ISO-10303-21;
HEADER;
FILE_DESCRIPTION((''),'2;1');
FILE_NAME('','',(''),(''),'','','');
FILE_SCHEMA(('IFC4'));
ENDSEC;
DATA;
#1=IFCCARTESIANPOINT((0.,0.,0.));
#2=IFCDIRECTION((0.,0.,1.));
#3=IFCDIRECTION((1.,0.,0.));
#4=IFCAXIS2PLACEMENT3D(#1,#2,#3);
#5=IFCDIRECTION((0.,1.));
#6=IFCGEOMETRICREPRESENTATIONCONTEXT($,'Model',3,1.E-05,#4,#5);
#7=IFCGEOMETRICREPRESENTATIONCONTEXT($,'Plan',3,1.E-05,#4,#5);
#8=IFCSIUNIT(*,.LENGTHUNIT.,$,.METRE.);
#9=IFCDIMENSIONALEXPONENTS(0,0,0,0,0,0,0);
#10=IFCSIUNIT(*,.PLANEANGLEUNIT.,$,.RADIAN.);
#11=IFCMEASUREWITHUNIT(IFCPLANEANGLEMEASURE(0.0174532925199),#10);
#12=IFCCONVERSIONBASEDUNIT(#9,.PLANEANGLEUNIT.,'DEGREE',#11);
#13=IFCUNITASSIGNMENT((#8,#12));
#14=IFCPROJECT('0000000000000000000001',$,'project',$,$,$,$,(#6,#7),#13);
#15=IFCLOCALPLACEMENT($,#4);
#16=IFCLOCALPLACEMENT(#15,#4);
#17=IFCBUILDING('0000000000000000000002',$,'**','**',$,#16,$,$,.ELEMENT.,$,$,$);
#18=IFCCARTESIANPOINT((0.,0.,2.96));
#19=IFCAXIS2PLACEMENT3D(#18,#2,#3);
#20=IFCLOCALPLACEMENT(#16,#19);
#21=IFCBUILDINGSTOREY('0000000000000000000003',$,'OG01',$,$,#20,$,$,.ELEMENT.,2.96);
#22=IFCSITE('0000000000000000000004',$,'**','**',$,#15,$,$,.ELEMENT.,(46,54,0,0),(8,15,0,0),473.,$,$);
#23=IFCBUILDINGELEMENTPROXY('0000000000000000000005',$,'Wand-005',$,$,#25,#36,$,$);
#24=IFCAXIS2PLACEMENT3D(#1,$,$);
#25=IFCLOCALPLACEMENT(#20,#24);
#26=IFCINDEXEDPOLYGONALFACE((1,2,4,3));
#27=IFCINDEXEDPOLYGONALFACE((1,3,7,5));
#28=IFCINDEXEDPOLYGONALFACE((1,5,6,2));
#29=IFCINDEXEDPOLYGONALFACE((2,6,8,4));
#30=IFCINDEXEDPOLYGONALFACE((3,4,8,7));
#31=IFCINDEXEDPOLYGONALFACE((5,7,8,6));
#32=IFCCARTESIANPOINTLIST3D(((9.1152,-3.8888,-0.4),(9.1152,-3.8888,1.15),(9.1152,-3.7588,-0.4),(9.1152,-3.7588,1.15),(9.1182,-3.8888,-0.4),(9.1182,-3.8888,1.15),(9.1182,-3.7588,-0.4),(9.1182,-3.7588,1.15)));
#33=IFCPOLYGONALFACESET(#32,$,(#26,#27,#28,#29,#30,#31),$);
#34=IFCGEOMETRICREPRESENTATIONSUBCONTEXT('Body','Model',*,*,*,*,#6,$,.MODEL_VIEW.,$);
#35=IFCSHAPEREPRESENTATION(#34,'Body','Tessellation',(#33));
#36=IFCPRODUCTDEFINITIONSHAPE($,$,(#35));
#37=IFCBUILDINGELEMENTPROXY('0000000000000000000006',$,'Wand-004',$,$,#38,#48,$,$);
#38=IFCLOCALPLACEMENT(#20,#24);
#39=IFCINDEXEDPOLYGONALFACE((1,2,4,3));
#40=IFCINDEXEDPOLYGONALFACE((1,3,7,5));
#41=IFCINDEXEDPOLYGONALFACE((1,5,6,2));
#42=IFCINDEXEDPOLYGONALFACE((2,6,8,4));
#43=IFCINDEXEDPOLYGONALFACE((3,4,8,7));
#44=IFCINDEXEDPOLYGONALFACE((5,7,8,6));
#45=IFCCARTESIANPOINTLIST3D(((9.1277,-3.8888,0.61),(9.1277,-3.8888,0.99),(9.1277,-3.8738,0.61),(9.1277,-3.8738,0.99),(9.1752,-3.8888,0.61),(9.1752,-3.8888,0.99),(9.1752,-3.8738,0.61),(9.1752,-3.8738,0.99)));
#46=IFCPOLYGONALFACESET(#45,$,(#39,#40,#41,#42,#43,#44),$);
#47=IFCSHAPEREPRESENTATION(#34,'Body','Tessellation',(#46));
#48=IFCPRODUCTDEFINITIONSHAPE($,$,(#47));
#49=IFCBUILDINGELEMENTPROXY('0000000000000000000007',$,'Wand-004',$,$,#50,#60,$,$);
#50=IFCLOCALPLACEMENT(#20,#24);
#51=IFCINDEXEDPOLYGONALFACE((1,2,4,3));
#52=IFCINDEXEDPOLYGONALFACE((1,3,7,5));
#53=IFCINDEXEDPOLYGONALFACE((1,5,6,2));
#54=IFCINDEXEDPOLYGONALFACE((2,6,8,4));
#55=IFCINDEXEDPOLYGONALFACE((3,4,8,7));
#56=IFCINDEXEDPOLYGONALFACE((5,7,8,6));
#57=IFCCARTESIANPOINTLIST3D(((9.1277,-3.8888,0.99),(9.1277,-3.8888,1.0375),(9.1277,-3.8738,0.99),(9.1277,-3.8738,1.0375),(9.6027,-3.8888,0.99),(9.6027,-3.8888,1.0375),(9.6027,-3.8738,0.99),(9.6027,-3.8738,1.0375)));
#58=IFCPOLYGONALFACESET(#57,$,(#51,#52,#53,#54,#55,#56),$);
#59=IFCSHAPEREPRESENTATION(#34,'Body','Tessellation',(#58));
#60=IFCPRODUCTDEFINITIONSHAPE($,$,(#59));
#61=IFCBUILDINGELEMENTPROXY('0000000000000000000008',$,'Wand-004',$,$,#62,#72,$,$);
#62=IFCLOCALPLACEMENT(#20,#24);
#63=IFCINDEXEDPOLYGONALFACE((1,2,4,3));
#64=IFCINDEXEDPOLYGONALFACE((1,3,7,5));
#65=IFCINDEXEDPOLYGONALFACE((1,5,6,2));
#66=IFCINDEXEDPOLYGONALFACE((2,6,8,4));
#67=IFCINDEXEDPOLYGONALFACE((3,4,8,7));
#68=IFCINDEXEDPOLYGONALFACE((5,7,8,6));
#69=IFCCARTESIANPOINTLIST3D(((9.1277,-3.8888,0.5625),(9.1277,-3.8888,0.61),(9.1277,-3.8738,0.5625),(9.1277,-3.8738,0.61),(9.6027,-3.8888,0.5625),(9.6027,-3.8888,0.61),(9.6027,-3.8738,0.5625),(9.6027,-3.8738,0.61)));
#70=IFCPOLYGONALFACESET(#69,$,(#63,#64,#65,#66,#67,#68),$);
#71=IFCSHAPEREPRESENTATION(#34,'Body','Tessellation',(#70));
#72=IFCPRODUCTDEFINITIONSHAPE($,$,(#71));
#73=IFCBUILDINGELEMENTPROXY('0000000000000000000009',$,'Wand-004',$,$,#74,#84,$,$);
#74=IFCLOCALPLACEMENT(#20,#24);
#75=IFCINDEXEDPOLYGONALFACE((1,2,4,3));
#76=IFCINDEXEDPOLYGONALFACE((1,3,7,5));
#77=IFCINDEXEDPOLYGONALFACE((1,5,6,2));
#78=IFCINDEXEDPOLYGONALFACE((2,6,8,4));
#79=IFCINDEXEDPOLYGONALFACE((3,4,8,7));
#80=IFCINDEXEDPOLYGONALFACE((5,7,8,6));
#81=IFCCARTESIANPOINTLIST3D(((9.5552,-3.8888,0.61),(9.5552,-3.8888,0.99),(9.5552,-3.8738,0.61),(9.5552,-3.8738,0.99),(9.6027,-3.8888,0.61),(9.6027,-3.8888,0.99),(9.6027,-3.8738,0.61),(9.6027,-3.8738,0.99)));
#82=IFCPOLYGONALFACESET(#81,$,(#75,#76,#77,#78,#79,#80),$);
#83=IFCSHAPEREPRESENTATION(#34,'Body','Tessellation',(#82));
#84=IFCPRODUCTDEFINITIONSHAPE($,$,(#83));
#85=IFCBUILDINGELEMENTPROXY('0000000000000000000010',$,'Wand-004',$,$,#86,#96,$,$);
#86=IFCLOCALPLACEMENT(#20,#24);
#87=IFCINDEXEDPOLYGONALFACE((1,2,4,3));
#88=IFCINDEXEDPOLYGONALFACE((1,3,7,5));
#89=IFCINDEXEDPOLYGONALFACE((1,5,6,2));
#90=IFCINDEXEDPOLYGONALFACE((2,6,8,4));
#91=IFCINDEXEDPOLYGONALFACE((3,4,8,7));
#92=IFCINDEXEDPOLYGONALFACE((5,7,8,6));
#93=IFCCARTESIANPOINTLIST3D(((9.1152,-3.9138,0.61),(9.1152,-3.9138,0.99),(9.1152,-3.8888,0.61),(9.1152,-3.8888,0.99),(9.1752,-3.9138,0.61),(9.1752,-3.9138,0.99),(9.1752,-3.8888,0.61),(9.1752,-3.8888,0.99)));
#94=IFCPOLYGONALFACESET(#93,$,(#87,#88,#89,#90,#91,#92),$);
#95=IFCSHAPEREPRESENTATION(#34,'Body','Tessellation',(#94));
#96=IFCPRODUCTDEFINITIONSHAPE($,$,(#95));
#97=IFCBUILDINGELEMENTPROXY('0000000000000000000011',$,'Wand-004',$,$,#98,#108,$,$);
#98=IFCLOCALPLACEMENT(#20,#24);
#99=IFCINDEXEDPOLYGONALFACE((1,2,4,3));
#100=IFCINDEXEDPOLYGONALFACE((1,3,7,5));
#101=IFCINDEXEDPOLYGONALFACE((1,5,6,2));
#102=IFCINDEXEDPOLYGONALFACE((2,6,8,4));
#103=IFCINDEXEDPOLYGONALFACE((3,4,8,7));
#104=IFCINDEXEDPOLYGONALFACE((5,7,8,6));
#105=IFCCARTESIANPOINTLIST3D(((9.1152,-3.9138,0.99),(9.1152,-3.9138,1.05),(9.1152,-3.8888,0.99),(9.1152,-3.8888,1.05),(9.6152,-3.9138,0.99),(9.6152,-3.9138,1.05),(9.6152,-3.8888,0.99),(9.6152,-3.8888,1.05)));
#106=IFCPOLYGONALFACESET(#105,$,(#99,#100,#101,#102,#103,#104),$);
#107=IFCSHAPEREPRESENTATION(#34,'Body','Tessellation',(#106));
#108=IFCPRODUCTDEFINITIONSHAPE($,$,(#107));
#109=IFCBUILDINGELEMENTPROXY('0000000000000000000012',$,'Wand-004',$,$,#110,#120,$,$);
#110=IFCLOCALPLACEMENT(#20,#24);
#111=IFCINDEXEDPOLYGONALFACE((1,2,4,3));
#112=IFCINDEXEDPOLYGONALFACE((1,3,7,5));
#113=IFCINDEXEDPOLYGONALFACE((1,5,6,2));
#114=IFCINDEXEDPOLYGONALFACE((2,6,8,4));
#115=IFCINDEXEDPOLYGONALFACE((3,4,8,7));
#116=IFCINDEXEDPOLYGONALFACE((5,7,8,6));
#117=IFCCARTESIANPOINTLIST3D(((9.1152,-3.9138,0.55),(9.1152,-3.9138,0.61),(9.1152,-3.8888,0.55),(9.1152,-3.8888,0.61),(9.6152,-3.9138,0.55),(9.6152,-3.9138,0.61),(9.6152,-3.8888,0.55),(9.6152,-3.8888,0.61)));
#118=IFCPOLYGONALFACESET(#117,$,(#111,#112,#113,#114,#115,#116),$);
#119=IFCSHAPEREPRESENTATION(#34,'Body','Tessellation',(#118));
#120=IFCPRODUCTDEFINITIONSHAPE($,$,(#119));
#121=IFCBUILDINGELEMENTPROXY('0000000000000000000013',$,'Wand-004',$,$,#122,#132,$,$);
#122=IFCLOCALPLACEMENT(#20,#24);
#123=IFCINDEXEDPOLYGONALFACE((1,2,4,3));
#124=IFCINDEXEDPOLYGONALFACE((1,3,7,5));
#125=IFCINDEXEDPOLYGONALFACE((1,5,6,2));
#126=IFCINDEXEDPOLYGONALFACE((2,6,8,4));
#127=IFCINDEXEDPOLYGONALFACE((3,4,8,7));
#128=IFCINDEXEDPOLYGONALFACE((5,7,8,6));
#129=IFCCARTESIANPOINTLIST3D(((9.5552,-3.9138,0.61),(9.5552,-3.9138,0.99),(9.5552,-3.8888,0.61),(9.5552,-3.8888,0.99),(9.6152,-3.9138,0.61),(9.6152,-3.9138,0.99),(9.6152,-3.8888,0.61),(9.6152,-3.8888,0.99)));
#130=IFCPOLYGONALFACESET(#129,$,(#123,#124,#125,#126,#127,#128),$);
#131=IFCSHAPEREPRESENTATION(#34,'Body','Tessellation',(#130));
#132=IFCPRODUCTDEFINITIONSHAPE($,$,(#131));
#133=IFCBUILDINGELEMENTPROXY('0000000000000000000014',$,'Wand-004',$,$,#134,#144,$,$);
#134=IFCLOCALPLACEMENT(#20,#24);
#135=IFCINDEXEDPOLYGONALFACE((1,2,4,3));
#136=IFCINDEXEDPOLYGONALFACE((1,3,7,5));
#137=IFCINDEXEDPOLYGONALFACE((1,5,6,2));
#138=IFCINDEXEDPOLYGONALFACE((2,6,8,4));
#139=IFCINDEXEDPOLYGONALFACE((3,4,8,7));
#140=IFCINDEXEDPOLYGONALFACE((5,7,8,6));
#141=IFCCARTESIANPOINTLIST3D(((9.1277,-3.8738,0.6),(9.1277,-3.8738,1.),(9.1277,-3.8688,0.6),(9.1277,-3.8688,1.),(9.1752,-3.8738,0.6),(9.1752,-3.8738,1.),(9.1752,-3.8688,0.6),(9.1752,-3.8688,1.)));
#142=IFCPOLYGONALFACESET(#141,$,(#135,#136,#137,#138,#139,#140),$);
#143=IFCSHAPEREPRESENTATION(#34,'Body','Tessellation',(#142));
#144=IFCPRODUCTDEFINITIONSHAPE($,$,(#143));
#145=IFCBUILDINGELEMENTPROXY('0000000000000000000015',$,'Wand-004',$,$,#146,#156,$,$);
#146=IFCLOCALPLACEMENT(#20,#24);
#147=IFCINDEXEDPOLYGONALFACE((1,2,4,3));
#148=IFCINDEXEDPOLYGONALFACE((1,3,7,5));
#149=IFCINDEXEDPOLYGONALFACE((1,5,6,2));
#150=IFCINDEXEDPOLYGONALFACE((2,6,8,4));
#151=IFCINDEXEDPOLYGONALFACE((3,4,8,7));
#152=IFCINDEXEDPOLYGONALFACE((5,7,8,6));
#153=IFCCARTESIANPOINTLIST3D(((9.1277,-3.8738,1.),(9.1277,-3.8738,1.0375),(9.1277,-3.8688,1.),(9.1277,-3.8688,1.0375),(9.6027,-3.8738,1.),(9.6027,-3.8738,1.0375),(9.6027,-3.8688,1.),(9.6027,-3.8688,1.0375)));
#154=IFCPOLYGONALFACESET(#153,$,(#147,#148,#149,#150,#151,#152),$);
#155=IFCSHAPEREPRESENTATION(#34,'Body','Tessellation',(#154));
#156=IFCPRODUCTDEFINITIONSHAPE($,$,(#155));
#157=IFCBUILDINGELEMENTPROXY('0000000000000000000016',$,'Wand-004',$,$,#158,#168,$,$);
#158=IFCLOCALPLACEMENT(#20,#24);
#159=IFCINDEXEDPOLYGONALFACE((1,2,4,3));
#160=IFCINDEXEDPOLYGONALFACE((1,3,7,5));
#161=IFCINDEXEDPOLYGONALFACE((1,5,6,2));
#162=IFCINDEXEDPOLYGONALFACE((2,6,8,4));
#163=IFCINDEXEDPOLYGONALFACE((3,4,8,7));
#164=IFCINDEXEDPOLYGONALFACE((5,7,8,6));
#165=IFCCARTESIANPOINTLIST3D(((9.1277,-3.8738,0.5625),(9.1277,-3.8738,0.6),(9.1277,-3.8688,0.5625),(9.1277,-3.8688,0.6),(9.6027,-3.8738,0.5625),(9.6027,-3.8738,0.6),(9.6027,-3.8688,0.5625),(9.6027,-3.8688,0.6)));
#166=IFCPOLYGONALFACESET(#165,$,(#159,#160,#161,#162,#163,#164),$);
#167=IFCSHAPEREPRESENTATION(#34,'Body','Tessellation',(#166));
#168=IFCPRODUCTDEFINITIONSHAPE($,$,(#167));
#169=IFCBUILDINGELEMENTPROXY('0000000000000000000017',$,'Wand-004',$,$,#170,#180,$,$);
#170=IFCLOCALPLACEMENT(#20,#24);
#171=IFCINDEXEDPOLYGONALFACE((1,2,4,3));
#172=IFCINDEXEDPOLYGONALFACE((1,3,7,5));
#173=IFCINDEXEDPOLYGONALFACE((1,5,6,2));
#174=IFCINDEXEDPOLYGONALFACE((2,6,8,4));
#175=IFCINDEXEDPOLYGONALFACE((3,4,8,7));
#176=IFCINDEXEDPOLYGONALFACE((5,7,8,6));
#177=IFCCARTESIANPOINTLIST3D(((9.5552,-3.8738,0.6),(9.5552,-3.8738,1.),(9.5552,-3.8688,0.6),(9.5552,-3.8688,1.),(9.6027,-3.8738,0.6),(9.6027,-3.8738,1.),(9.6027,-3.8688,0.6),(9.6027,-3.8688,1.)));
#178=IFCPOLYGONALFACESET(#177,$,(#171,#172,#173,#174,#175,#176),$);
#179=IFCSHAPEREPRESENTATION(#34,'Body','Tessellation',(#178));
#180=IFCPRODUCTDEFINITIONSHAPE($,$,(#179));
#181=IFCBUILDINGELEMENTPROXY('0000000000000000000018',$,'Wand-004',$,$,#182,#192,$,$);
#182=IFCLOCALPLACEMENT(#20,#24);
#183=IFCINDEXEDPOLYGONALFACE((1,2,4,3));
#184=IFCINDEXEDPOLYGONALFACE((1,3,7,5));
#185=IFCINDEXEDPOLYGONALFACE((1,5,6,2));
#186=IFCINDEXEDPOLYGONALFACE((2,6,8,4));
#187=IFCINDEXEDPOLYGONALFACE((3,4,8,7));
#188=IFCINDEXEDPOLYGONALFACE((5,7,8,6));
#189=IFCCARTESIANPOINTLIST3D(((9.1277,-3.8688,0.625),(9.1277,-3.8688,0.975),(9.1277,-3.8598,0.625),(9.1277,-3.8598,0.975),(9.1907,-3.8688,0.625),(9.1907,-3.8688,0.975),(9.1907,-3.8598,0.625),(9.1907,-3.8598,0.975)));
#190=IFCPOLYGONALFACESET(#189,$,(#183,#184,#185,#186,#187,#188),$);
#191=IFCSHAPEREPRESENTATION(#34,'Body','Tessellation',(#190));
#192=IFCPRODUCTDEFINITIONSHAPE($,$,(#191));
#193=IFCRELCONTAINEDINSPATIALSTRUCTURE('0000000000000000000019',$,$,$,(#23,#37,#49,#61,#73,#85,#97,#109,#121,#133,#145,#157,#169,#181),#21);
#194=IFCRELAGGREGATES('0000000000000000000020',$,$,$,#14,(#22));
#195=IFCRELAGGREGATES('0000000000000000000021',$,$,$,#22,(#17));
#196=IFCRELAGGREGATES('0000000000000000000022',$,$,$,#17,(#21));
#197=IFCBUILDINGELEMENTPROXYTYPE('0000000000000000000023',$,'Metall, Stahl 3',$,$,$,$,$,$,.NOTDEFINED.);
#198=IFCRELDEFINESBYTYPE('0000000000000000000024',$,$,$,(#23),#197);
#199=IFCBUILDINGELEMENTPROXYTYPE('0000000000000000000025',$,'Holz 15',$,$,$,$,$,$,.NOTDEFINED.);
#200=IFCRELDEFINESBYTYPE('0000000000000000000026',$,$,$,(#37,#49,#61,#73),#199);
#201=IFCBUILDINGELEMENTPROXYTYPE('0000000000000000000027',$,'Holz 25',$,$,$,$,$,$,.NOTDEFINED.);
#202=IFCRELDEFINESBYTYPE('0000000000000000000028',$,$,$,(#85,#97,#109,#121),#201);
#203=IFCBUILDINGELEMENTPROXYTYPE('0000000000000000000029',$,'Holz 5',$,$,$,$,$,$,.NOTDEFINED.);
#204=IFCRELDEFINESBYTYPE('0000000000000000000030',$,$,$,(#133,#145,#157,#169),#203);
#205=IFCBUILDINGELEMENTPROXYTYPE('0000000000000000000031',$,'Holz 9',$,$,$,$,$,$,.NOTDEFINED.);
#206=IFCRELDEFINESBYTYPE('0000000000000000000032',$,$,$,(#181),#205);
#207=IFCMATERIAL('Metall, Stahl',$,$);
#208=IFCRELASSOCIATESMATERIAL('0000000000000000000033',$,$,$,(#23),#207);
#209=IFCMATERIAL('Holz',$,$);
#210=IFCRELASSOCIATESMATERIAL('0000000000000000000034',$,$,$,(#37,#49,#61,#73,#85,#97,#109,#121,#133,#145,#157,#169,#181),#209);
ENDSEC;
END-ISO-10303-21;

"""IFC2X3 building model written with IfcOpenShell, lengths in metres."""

from ifc_helpers import new_model, entity, si_unit, converted_unit, direction, frame, origin_with_axes, place, context, subcontext, project, spatial, polyline, outline, extrude, material, type_object, element, save


model = new_model("IFC2X3")

# Units and contexts
model_context = context("Model", 3, precision=1e-05, world=origin_with_axes(), true_north=direction((0.0, 1.0)))
plan_context = context("Plan", 3, precision=1e-05, world=origin_with_axes(), true_north=direction((0.0, 1.0)))
body_context = subcontext(model_context, "Body", "Model", "MODEL_VIEW")
ifc_project = project(units=[si_unit("LENGTHUNIT", "METRE"), converted_unit("PLANEANGLEUNIT", "DEGREE", entity("IfcPlaneAngleMeasure", 0.0174532925199), si_unit("PLANEANGLEUNIT", "RADIAN"), dimensions=[0, 0, 0, 0, 0, 0, 0])], contexts=[model_context, plan_context])

# Site, building, storey
site_placement = place(None, origin_with_axes())
site = spatial("IfcSite", under=ifc_project, at=site_placement, Name="**", Description="**", CompositionType="ELEMENT", RefLatitude=(46, 54, 0, 0), RefLongitude=(8, 15, 0, 0), RefElevation=473.0)
building_placement = place(site_placement, origin_with_axes())
building = spatial("IfcBuilding", under=site, at=building_placement, Name="**", Description="**", CompositionType="ELEMENT")
storey_placement = place(building_placement, frame((0.0, 0.0, 2.96), z_axis=(0.0, 0.0, 1.0), x_axis=(1.0, 0.0, 0.0)))
storey = spatial("IfcBuildingStorey", under=building, at=storey_placement, Name="OG01", CompositionType="ELEMENT", Elevation=2.96)

# Building element proxies
ifc_material_1 = material(Name="Metall, Stahl")
building_element_proxy_type_1 = type_object("IfcBuildingElementProxyType", Name="Metall, Stahl 3", PredefinedType="NOTDEFINED")
proxy_1_placement = place(storey_placement, frame((9.1152, -3.7588, -0.4), z_axis=(0.0, 0.0, 1.0), x_axis=(0.0, -1.0, 0.0)))
element("IfcBuildingElementProxy", 1, at=proxy_1_placement, inside=storey, type_object=building_element_proxy_type_1, material=ifc_material_1, Name="Wand-005", context=body_context, shape_type="SweptSolid", body=[
    extrude(outline(polyline([(0.0, 0.0), (0.13, 0.0), (0.13, 0.003), (0.0, 0.003), (0.0, 0.0)])), origin_with_axes(), (0.0, 0.0, 1.0), 1.55),
])
ifc_material_2 = material(Name="Holz")
building_element_proxy_type_2 = type_object("IfcBuildingElementProxyType", Name="Holz 15", PredefinedType="NOTDEFINED")
proxy_2_placement = place(storey_placement, frame((9.1277, -3.8888, 0.61), z_axis=(0.0, 0.0, 1.0), x_axis=(1.0, 0.0, 0.0)))
element("IfcBuildingElementProxy", 2, at=proxy_2_placement, inside=storey, type_object=building_element_proxy_type_2, material=ifc_material_2, Name="Wand-004", context=body_context, shape_type="SweptSolid", body=[
    extrude(outline(polyline([(0.0, 0.0), (0.0475, 0.0), (0.0475, 0.015), (0.0, 0.015), (0.0, 0.0)])), origin_with_axes(), (0.0, 0.0, 1.0), 0.38),
])
for number, where, z_axis, x_axis, name in (
    (3, (9.6027, -3.8738, 0.99), (0.0, 0.0, 1.0), (-1.0, 0.0, 0.0), "Wand-004"),
    (4, (9.6027, -3.8738, 0.5625), (0.0, 0.0, 1.0), (-1.0, 0.0, 0.0), "Wand-004"),
):
    element("IfcBuildingElementProxy", number, at=place(storey_placement, frame(where, z_axis=z_axis, x_axis=x_axis)), inside=storey, type_object=building_element_proxy_type_2, material=ifc_material_2, Name=name, context=body_context, shape_type="SweptSolid", body=[
        extrude(outline(polyline([(0.0, 0.0), (0.475, 0.0), (0.475, 0.015), (0.0, 0.015), (0.0, 0.0)])), origin_with_axes(), (0.0, 0.0, 1.0), 0.0475),
    ])
proxy_3_placement = place(storey_placement, frame((9.5552, -3.8888, 0.61), z_axis=(0.0, 0.0, 1.0), x_axis=(1.0, 0.0, 0.0)))
element("IfcBuildingElementProxy", 5, at=proxy_3_placement, inside=storey, type_object=building_element_proxy_type_2, material=ifc_material_2, Name="Wand-004", context=body_context, shape_type="SweptSolid", body=[
    extrude(outline(polyline([(0.0, 0.0), (0.0475, 0.0), (0.0475, 0.015), (0.0, 0.015), (0.0, 0.0)])), origin_with_axes(), (0.0, 0.0, 1.0), 0.38),
])
building_element_proxy_type_3 = type_object("IfcBuildingElementProxyType", Name="Holz 25", PredefinedType="NOTDEFINED")
proxy_4_placement = place(storey_placement, frame((9.1152, -3.9138, 0.61), z_axis=(0.0, 0.0, 1.0), x_axis=(1.0, 0.0, 0.0)))
element("IfcBuildingElementProxy", 6, at=proxy_4_placement, inside=storey, type_object=building_element_proxy_type_3, material=ifc_material_2, Name="Wand-004", context=body_context, shape_type="SweptSolid", body=[
    extrude(outline(polyline([(0.0, 0.0), (0.06, 0.0), (0.06, 0.025), (0.0, 0.025), (0.0, 0.0)])), origin_with_axes(), (0.0, 0.0, 1.0), 0.38),
])
for number, where, z_axis, x_axis, name in (
    (7, (9.6152, -3.8888, 0.99), (0.0, 0.0, 1.0), (-1.0, 0.0, 0.0), "Wand-004"),
    (8, (9.6152, -3.8888, 0.55), (0.0, 0.0, 1.0), (-1.0, 0.0, 0.0), "Wand-004"),
):
    element("IfcBuildingElementProxy", number, at=place(storey_placement, frame(where, z_axis=z_axis, x_axis=x_axis)), inside=storey, type_object=building_element_proxy_type_3, material=ifc_material_2, Name=name, context=body_context, shape_type="SweptSolid", body=[
        extrude(outline(polyline([(0.0, 0.0), (0.5, 0.0), (0.5, 0.025), (0.0, 0.025), (0.0, 0.0)])), origin_with_axes(), (0.0, 0.0, 1.0), 0.06),
    ])
proxy_5_placement = place(storey_placement, frame((9.5552, -3.9138, 0.61), z_axis=(0.0, 0.0, 1.0), x_axis=(1.0, 0.0, 0.0)))
element("IfcBuildingElementProxy", 9, at=proxy_5_placement, inside=storey, type_object=building_element_proxy_type_3, material=ifc_material_2, Name="Wand-004", context=body_context, shape_type="SweptSolid", body=[
    extrude(outline(polyline([(0.0, 0.0), (0.06, 0.0), (0.06, 0.025), (0.0, 0.025), (0.0, 0.0)])), origin_with_axes(), (0.0, 0.0, 1.0), 0.38),
])
building_element_proxy_type_4 = type_object("IfcBuildingElementProxyType", Name="Holz 5", PredefinedType="NOTDEFINED")
proxy_6_placement = place(storey_placement, frame((9.1277, -3.8738, 0.6), z_axis=(0.0, 0.0, 1.0), x_axis=(1.0, 0.0, 0.0)))
element("IfcBuildingElementProxy", 10, at=proxy_6_placement, inside=storey, type_object=building_element_proxy_type_4, material=ifc_material_2, Name="Wand-004", context=body_context, shape_type="SweptSolid", body=[
    extrude(outline(polyline([(0.0, 0.0), (0.0475, 0.0), (0.0475, 0.005), (0.0, 0.005), (0.0, 0.0)])), origin_with_axes(), (0.0, 0.0, 1.0), 0.4),
])
for number, where, z_axis, x_axis, name in (
    (11, (9.6027, -3.8738, 1.0), (0.0, 0.0, 1.0), (-1.0, 0.0, 0.0), "Wand-004"),
    (12, (9.6027, -3.8738, 0.5625), (0.0, 0.0, 1.0), (-1.0, 0.0, 0.0), "Wand-004"),
):
    element("IfcBuildingElementProxy", number, at=place(storey_placement, frame(where, z_axis=z_axis, x_axis=x_axis)), inside=storey, type_object=building_element_proxy_type_4, material=ifc_material_2, Name=name, context=body_context, shape_type="SweptSolid", body=[
        extrude(outline(polyline([(0.0, -0.005), (0.475, -0.005), (0.475, 0.0), (0.0, 0.0), (0.0, -0.005)])), origin_with_axes(), (0.0, 0.0, 1.0), 0.0375),
    ])
proxy_7_placement = place(storey_placement, frame((9.5552, -3.8738, 0.6), z_axis=(0.0, 0.0, 1.0), x_axis=(1.0, 0.0, 0.0)))
element("IfcBuildingElementProxy", 13, at=proxy_7_placement, inside=storey, type_object=building_element_proxy_type_4, material=ifc_material_2, Name="Wand-004", context=body_context, shape_type="SweptSolid", body=[
    extrude(outline(polyline([(0.0, 0.0), (0.0475, 0.0), (0.0475, 0.005), (0.0, 0.005), (0.0, 0.0)])), origin_with_axes(), (0.0, 0.0, 1.0), 0.4),
])
building_element_proxy_type_5 = type_object("IfcBuildingElementProxyType", Name="Holz 9", PredefinedType="NOTDEFINED")
for number, where, z_axis, x_axis, name in (
    (14, (9.1277, -3.8688, 0.625), (0.0, 0.0, 1.0), (1.0, 0.0, 0.0), "Wand-004"),
):
    element("IfcBuildingElementProxy", number, at=place(storey_placement, frame(where, z_axis=z_axis, x_axis=x_axis)), inside=storey, type_object=building_element_proxy_type_5, material=ifc_material_2, Name=name, context=body_context, shape_type="SweptSolid", body=[
        extrude(outline(polyline([(0.0, 0.0), (0.063, 0.0), (0.063, 0.009), (0.0, 0.009), (0.0, 0.0)])), origin_with_axes(), (0.0, 0.0, 1.0), 0.35),
    ])

save(model, "model.ifc")
